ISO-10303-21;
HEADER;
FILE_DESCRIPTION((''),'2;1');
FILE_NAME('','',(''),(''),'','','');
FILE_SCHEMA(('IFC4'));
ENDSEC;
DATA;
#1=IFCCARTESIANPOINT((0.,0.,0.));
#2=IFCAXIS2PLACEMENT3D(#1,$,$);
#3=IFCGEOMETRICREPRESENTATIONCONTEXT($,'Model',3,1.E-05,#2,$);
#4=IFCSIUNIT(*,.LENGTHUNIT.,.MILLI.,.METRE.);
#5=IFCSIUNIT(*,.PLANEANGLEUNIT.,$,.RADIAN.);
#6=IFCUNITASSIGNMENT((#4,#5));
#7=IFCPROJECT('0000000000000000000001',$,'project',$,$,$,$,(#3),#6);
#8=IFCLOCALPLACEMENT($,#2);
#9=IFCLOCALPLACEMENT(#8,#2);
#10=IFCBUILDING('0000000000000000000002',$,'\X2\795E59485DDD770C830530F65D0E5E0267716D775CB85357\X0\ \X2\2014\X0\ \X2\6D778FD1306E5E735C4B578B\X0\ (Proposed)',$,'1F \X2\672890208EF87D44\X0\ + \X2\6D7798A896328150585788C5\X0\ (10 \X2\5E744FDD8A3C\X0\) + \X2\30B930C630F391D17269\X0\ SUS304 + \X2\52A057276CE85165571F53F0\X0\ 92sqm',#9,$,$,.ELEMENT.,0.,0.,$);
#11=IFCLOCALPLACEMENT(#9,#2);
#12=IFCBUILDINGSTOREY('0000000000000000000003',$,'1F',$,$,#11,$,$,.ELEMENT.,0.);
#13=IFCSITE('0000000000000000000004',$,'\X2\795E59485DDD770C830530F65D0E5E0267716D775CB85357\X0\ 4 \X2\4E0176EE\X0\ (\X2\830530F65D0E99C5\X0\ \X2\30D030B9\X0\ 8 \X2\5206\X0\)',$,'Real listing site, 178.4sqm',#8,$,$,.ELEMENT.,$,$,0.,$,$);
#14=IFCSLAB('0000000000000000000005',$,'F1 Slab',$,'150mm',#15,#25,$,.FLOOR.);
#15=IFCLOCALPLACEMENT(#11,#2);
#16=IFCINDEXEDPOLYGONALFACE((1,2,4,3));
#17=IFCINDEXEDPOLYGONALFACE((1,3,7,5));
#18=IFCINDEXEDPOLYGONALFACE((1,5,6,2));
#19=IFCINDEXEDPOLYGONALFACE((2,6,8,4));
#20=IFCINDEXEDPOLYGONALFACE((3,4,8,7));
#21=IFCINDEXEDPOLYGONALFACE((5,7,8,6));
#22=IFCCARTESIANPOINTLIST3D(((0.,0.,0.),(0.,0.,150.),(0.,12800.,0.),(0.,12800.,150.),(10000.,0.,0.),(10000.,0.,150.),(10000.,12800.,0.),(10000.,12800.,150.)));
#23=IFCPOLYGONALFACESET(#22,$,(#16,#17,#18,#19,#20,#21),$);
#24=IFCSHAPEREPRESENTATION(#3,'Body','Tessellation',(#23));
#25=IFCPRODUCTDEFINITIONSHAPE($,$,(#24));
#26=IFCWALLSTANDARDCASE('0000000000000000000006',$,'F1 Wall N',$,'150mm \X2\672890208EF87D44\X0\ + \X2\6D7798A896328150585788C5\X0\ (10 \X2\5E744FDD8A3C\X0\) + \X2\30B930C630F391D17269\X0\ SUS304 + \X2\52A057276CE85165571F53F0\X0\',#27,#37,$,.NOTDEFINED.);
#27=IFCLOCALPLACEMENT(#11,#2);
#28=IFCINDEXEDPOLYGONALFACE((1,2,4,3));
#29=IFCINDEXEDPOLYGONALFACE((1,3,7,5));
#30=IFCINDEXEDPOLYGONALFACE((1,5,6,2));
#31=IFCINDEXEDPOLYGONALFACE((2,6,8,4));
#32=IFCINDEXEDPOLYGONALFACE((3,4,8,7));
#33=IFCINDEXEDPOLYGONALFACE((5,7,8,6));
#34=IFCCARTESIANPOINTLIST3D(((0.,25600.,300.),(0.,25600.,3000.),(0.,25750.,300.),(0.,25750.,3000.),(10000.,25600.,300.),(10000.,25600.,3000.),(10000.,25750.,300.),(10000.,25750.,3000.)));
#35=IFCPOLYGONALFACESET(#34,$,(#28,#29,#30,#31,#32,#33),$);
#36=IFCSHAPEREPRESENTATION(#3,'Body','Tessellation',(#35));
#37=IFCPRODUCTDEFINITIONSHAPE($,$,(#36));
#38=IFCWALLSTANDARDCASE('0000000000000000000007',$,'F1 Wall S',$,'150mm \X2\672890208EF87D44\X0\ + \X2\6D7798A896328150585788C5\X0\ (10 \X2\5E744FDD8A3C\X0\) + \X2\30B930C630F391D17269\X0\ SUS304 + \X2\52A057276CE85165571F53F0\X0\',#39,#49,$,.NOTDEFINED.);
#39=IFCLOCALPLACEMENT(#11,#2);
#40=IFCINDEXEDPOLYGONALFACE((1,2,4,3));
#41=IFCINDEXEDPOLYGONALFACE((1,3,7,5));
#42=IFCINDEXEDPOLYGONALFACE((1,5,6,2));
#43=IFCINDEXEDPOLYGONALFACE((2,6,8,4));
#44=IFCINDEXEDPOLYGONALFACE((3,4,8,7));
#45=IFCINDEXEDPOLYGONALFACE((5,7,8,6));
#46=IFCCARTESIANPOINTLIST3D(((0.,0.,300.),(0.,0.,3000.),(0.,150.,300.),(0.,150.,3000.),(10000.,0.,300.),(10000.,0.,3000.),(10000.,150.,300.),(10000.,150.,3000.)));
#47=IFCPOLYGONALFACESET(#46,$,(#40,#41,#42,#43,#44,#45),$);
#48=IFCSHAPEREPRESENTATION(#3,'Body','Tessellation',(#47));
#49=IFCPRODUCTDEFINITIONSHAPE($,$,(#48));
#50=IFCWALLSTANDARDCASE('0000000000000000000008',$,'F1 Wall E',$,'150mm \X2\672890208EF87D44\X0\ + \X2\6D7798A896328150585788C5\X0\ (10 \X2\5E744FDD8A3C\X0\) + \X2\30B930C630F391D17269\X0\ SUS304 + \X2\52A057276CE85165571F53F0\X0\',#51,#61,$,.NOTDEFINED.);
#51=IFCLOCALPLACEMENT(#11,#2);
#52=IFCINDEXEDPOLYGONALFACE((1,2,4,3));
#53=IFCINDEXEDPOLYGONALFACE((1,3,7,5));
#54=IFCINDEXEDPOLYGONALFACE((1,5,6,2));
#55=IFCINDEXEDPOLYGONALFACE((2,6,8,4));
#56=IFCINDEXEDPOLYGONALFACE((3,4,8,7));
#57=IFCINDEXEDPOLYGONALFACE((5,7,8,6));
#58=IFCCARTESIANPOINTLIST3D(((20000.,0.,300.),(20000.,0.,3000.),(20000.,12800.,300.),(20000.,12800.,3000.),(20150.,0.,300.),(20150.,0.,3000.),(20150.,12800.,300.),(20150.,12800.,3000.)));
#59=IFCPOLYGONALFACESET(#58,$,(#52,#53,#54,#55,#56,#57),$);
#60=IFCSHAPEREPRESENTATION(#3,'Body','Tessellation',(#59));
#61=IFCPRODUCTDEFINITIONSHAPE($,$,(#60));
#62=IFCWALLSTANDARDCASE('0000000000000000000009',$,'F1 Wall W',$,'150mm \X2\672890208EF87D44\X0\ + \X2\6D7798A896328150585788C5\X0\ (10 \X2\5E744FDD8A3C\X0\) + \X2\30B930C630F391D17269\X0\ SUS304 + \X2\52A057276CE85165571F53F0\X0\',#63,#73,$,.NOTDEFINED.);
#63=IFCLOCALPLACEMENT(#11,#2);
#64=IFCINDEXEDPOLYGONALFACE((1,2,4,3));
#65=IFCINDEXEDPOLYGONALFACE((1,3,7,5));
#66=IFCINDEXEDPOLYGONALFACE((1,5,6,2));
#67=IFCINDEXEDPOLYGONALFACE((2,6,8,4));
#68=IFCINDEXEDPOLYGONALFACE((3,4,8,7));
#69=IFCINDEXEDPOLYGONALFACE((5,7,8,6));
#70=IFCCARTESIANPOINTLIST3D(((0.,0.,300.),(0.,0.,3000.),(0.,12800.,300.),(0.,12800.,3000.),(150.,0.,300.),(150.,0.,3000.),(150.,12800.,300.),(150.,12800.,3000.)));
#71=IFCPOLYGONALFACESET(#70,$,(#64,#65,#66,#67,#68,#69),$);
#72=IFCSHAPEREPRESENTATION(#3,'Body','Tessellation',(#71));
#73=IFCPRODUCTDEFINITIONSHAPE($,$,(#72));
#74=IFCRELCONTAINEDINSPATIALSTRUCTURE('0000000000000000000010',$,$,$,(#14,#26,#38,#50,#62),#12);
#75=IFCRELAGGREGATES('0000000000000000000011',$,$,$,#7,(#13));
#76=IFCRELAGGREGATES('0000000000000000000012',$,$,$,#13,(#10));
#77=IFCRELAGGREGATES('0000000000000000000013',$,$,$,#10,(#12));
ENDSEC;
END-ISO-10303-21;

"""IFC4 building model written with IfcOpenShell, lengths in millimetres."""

from ifc_helpers import new_model, si_unit, frame, frame_2d, origin, place, context, project, spatial, rectangle, extrude, element, save


model = new_model("IFC4")

# Units and contexts
model_context = context("Model", 3, precision=1e-05, world=origin())
ifc_project = project(units=[si_unit("LENGTHUNIT", "METRE", prefix="MILLI"), si_unit("PLANEANGLEUNIT", "RADIAN")], contexts=[model_context])

# Site, building, storey
site_placement = place(None, origin())
site = spatial("IfcSite", under=ifc_project, at=site_placement, Name="神奈川県茅ヶ崎市東海岸南 4 丁目 (茅ヶ崎駅 バス 8 分)", ObjectType="Real listing site, 178.4sqm", CompositionType="ELEMENT", RefElevation=0.0)
building_placement = place(site_placement, origin())
building = spatial("IfcBuilding", under=site, at=building_placement, Name="神奈川県茅ヶ崎市東海岸南 — 海近の平屋型 (Proposed)", ObjectType="1F 木造軸組 + 海風防腐塗装 (10 年保証) + ステン金物 SUS304 + 加圧注入土台 92sqm", CompositionType="ELEMENT", ElevationOfRefHeight=0.0, ElevationOfTerrain=0.0)
storey_placement = place(building_placement, origin())
storey = spatial("IfcBuildingStorey", under=building, at=storey_placement, Name="1F", CompositionType="ELEMENT", Elevation=0.0)

# Slab
slab_placement = place(storey_placement, origin())
element("IfcSlab", 1, at=slab_placement, inside=storey, Name="F1 Slab", ObjectType="150mm", PredefinedType="FLOOR", context=model_context, shape_type="SweptSolid", body=[
    extrude(rectangle(XDim=10000.0, YDim=12800.0, at=frame_2d((5000.0, 6400.0))), origin(), (0.0, 0.0, 1.0), 150.0),
])

# Walls
wall_1_placement = place(storey_placement, frame((0.0, 12800.0, 150.0)))
element("IfcWallStandardCase", 2, at=wall_1_placement, inside=storey, Name="F1 Wall N", ObjectType="150mm 木造軸組 + 海風防腐塗装 (10 年保証) + ステン金物 SUS304 + 加圧注入土台", PredefinedType="NOTDEFINED", context=model_context, shape_type="SweptSolid", body=[
    extrude(rectangle(XDim=10000.0, YDim=150.0, at=frame_2d((5000.0, 75.0))), frame((0.0, 12800.0, 150.0)), (0.0, 0.0, 1.0), 2700.0),
])
wall_2_placement = place(storey_placement, frame((0.0, 0.0, 150.0)))
element("IfcWallStandardCase", 3, at=wall_2_placement, inside=storey, Name="F1 Wall S", ObjectType="150mm 木造軸組 + 海風防腐塗装 (10 年保証) + ステン金物 SUS304 + 加圧注入土台", PredefinedType="NOTDEFINED", context=model_context, shape_type="SweptSolid", body=[
    extrude(rectangle(XDim=10000.0, YDim=150.0, at=frame_2d((5000.0, 75.0))), frame((0.0, 0.0, 150.0)), (0.0, 0.0, 1.0), 2700.0),
])
wall_3_placement = place(storey_placement, frame((10000.0, 0.0, 150.0)))
element("IfcWallStandardCase", 4, at=wall_3_placement, inside=storey, Name="F1 Wall E", ObjectType="150mm 木造軸組 + 海風防腐塗装 (10 年保証) + ステン金物 SUS304 + 加圧注入土台", PredefinedType="NOTDEFINED", context=model_context, shape_type="SweptSolid", body=[
    extrude(rectangle(XDim=150.0, YDim=12800.0, at=frame_2d((75.0, 6400.0))), frame((10000.0, 0.0, 150.0)), (0.0, 0.0, 1.0), 2700.0),
])
wall_4_placement = place(storey_placement, frame((0.0, 0.0, 150.0)))
element("IfcWallStandardCase", 5, at=wall_4_placement, inside=storey, Name="F1 Wall W", ObjectType="150mm 木造軸組 + 海風防腐塗装 (10 年保証) + ステン金物 SUS304 + 加圧注入土台", PredefinedType="NOTDEFINED", context=model_context, shape_type="SweptSolid", body=[
    extrude(rectangle(XDim=150.0, YDim=12800.0, at=frame_2d((75.0, 6400.0))), frame((0.0, 0.0, 150.0)), (0.0, 0.0, 1.0), 2700.0),
])

save(model, "model.ifc")
